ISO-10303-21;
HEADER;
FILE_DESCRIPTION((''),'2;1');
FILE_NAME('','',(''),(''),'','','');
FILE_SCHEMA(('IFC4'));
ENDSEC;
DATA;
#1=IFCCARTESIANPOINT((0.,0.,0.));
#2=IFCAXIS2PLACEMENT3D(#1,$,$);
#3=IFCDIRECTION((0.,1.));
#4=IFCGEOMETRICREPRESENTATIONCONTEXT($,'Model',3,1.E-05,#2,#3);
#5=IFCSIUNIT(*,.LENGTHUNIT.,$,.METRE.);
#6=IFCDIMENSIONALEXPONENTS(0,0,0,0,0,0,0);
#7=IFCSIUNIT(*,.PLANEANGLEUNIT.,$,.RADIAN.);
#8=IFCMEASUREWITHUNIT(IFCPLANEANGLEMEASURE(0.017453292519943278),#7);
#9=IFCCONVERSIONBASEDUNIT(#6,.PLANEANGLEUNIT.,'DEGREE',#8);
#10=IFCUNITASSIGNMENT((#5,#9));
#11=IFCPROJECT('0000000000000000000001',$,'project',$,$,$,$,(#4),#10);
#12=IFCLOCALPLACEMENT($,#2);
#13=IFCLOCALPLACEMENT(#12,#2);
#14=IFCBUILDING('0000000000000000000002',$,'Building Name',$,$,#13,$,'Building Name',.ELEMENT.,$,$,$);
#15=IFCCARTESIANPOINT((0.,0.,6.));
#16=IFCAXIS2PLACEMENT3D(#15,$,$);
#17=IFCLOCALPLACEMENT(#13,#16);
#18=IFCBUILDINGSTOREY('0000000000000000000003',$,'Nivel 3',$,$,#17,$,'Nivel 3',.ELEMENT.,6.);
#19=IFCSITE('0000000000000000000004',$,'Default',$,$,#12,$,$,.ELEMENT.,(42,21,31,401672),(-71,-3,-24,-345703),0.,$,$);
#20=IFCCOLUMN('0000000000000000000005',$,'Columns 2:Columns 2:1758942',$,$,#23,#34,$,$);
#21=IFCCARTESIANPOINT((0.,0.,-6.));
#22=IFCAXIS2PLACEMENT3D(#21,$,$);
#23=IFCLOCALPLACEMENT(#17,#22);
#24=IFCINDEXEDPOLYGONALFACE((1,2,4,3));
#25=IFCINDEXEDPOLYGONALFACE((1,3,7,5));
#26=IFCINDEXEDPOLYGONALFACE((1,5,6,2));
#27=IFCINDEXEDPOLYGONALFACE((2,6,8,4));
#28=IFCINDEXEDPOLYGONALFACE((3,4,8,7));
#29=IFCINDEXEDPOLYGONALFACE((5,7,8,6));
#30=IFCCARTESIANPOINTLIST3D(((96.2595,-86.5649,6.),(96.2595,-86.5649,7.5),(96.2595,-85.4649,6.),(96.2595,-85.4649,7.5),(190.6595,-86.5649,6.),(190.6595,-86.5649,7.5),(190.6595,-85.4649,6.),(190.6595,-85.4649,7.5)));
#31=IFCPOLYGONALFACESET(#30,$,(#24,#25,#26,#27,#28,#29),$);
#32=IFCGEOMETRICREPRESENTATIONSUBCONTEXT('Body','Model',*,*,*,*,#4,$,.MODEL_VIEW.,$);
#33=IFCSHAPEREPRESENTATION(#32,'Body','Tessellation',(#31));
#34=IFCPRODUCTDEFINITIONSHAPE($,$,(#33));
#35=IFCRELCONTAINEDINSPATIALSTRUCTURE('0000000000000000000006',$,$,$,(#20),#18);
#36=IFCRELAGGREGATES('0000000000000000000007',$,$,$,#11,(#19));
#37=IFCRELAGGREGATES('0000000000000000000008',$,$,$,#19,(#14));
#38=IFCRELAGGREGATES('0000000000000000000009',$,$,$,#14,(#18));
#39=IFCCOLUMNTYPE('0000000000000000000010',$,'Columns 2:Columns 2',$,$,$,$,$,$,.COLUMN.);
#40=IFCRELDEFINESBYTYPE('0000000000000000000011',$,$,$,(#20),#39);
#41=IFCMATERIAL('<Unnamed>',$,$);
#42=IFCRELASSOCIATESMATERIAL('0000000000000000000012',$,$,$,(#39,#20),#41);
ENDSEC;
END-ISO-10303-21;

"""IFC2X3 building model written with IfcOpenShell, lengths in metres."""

from ifc_helpers import new_model, entity, si_unit, converted_unit, direction, frame, frame_2d, origin, place, context, subcontext, project, spatial, rectangle, extrude, source, transform, mapped, material, type_object, type_shapes, element, save


model = new_model("IFC2X3")

# Units and contexts
model_context = context("Model", 3, precision=1e-05, world=origin(), true_north=direction((0.0, 1.0)))
body_context = subcontext(model_context, "Body", "Model", "MODEL_VIEW")
ifc_project = project(units=[si_unit("LENGTHUNIT", "METRE"), converted_unit("PLANEANGLEUNIT", "DEGREE", entity("IfcPlaneAngleMeasure", 0.017453292519943278), si_unit("PLANEANGLEUNIT", "RADIAN"), dimensions=[0, 0, 0, 0, 0, 0, 0])], contexts=[model_context])

# Site, building, storey
site_placement = place(None, origin())
site = spatial("IfcSite", under=ifc_project, at=site_placement, Name="Default", CompositionType="ELEMENT", RefLatitude=(42, 21, 31, 401672), RefLongitude=(-71, -3, -24, -345703), RefElevation=0.0)
building_placement = place(site_placement, origin())
building = spatial("IfcBuilding", under=site, at=building_placement, Name="Building Name", LongName="Building Name", CompositionType="ELEMENT")
storey_placement = place(building_placement, frame((0.0, 0.0, 6.0)))
storey = spatial("IfcBuildingStorey", under=building, at=storey_placement, Name="Nivel 3", LongName="Nivel 3", CompositionType="ELEMENT", Elevation=6.0)

# Column
ifc_material_1 = material(Name="<Unnamed>")
column_type = type_object("IfcColumnType", Name="Columns 2:Columns 2", PredefinedType="COLUMN", material=ifc_material_1)
shared_shape = source(origin(), body_context, "Body", "SweptSolid", [
    extrude(rectangle(XDim=1.1, YDim=94.4, at=frame_2d((0.0, 0.0), x_axis=(1.0, 0.0))), frame((143.4595, -86.0149, 6.0), z_axis=(0.0, 0.0, 1.0), x_axis=(0.0, 1.0, 0.0)), (0.0, 0.0, 1.0), 1.5),
])
type_shapes(column_type, [shared_shape])
column_placement = place(storey_placement, frame((0.0, 0.0, -6.0)))
element("IfcColumn", 1, at=column_placement, inside=storey, type_object=column_type, material=ifc_material_1, Name="Columns 2:Columns 2:1758942", context=body_context, shape_type="MappedRepresentation", body=[
    mapped(shared_shape, transform((0.0, 0.0, 0.0), scale=1.0)),
])

save(model, "model.ifc")
